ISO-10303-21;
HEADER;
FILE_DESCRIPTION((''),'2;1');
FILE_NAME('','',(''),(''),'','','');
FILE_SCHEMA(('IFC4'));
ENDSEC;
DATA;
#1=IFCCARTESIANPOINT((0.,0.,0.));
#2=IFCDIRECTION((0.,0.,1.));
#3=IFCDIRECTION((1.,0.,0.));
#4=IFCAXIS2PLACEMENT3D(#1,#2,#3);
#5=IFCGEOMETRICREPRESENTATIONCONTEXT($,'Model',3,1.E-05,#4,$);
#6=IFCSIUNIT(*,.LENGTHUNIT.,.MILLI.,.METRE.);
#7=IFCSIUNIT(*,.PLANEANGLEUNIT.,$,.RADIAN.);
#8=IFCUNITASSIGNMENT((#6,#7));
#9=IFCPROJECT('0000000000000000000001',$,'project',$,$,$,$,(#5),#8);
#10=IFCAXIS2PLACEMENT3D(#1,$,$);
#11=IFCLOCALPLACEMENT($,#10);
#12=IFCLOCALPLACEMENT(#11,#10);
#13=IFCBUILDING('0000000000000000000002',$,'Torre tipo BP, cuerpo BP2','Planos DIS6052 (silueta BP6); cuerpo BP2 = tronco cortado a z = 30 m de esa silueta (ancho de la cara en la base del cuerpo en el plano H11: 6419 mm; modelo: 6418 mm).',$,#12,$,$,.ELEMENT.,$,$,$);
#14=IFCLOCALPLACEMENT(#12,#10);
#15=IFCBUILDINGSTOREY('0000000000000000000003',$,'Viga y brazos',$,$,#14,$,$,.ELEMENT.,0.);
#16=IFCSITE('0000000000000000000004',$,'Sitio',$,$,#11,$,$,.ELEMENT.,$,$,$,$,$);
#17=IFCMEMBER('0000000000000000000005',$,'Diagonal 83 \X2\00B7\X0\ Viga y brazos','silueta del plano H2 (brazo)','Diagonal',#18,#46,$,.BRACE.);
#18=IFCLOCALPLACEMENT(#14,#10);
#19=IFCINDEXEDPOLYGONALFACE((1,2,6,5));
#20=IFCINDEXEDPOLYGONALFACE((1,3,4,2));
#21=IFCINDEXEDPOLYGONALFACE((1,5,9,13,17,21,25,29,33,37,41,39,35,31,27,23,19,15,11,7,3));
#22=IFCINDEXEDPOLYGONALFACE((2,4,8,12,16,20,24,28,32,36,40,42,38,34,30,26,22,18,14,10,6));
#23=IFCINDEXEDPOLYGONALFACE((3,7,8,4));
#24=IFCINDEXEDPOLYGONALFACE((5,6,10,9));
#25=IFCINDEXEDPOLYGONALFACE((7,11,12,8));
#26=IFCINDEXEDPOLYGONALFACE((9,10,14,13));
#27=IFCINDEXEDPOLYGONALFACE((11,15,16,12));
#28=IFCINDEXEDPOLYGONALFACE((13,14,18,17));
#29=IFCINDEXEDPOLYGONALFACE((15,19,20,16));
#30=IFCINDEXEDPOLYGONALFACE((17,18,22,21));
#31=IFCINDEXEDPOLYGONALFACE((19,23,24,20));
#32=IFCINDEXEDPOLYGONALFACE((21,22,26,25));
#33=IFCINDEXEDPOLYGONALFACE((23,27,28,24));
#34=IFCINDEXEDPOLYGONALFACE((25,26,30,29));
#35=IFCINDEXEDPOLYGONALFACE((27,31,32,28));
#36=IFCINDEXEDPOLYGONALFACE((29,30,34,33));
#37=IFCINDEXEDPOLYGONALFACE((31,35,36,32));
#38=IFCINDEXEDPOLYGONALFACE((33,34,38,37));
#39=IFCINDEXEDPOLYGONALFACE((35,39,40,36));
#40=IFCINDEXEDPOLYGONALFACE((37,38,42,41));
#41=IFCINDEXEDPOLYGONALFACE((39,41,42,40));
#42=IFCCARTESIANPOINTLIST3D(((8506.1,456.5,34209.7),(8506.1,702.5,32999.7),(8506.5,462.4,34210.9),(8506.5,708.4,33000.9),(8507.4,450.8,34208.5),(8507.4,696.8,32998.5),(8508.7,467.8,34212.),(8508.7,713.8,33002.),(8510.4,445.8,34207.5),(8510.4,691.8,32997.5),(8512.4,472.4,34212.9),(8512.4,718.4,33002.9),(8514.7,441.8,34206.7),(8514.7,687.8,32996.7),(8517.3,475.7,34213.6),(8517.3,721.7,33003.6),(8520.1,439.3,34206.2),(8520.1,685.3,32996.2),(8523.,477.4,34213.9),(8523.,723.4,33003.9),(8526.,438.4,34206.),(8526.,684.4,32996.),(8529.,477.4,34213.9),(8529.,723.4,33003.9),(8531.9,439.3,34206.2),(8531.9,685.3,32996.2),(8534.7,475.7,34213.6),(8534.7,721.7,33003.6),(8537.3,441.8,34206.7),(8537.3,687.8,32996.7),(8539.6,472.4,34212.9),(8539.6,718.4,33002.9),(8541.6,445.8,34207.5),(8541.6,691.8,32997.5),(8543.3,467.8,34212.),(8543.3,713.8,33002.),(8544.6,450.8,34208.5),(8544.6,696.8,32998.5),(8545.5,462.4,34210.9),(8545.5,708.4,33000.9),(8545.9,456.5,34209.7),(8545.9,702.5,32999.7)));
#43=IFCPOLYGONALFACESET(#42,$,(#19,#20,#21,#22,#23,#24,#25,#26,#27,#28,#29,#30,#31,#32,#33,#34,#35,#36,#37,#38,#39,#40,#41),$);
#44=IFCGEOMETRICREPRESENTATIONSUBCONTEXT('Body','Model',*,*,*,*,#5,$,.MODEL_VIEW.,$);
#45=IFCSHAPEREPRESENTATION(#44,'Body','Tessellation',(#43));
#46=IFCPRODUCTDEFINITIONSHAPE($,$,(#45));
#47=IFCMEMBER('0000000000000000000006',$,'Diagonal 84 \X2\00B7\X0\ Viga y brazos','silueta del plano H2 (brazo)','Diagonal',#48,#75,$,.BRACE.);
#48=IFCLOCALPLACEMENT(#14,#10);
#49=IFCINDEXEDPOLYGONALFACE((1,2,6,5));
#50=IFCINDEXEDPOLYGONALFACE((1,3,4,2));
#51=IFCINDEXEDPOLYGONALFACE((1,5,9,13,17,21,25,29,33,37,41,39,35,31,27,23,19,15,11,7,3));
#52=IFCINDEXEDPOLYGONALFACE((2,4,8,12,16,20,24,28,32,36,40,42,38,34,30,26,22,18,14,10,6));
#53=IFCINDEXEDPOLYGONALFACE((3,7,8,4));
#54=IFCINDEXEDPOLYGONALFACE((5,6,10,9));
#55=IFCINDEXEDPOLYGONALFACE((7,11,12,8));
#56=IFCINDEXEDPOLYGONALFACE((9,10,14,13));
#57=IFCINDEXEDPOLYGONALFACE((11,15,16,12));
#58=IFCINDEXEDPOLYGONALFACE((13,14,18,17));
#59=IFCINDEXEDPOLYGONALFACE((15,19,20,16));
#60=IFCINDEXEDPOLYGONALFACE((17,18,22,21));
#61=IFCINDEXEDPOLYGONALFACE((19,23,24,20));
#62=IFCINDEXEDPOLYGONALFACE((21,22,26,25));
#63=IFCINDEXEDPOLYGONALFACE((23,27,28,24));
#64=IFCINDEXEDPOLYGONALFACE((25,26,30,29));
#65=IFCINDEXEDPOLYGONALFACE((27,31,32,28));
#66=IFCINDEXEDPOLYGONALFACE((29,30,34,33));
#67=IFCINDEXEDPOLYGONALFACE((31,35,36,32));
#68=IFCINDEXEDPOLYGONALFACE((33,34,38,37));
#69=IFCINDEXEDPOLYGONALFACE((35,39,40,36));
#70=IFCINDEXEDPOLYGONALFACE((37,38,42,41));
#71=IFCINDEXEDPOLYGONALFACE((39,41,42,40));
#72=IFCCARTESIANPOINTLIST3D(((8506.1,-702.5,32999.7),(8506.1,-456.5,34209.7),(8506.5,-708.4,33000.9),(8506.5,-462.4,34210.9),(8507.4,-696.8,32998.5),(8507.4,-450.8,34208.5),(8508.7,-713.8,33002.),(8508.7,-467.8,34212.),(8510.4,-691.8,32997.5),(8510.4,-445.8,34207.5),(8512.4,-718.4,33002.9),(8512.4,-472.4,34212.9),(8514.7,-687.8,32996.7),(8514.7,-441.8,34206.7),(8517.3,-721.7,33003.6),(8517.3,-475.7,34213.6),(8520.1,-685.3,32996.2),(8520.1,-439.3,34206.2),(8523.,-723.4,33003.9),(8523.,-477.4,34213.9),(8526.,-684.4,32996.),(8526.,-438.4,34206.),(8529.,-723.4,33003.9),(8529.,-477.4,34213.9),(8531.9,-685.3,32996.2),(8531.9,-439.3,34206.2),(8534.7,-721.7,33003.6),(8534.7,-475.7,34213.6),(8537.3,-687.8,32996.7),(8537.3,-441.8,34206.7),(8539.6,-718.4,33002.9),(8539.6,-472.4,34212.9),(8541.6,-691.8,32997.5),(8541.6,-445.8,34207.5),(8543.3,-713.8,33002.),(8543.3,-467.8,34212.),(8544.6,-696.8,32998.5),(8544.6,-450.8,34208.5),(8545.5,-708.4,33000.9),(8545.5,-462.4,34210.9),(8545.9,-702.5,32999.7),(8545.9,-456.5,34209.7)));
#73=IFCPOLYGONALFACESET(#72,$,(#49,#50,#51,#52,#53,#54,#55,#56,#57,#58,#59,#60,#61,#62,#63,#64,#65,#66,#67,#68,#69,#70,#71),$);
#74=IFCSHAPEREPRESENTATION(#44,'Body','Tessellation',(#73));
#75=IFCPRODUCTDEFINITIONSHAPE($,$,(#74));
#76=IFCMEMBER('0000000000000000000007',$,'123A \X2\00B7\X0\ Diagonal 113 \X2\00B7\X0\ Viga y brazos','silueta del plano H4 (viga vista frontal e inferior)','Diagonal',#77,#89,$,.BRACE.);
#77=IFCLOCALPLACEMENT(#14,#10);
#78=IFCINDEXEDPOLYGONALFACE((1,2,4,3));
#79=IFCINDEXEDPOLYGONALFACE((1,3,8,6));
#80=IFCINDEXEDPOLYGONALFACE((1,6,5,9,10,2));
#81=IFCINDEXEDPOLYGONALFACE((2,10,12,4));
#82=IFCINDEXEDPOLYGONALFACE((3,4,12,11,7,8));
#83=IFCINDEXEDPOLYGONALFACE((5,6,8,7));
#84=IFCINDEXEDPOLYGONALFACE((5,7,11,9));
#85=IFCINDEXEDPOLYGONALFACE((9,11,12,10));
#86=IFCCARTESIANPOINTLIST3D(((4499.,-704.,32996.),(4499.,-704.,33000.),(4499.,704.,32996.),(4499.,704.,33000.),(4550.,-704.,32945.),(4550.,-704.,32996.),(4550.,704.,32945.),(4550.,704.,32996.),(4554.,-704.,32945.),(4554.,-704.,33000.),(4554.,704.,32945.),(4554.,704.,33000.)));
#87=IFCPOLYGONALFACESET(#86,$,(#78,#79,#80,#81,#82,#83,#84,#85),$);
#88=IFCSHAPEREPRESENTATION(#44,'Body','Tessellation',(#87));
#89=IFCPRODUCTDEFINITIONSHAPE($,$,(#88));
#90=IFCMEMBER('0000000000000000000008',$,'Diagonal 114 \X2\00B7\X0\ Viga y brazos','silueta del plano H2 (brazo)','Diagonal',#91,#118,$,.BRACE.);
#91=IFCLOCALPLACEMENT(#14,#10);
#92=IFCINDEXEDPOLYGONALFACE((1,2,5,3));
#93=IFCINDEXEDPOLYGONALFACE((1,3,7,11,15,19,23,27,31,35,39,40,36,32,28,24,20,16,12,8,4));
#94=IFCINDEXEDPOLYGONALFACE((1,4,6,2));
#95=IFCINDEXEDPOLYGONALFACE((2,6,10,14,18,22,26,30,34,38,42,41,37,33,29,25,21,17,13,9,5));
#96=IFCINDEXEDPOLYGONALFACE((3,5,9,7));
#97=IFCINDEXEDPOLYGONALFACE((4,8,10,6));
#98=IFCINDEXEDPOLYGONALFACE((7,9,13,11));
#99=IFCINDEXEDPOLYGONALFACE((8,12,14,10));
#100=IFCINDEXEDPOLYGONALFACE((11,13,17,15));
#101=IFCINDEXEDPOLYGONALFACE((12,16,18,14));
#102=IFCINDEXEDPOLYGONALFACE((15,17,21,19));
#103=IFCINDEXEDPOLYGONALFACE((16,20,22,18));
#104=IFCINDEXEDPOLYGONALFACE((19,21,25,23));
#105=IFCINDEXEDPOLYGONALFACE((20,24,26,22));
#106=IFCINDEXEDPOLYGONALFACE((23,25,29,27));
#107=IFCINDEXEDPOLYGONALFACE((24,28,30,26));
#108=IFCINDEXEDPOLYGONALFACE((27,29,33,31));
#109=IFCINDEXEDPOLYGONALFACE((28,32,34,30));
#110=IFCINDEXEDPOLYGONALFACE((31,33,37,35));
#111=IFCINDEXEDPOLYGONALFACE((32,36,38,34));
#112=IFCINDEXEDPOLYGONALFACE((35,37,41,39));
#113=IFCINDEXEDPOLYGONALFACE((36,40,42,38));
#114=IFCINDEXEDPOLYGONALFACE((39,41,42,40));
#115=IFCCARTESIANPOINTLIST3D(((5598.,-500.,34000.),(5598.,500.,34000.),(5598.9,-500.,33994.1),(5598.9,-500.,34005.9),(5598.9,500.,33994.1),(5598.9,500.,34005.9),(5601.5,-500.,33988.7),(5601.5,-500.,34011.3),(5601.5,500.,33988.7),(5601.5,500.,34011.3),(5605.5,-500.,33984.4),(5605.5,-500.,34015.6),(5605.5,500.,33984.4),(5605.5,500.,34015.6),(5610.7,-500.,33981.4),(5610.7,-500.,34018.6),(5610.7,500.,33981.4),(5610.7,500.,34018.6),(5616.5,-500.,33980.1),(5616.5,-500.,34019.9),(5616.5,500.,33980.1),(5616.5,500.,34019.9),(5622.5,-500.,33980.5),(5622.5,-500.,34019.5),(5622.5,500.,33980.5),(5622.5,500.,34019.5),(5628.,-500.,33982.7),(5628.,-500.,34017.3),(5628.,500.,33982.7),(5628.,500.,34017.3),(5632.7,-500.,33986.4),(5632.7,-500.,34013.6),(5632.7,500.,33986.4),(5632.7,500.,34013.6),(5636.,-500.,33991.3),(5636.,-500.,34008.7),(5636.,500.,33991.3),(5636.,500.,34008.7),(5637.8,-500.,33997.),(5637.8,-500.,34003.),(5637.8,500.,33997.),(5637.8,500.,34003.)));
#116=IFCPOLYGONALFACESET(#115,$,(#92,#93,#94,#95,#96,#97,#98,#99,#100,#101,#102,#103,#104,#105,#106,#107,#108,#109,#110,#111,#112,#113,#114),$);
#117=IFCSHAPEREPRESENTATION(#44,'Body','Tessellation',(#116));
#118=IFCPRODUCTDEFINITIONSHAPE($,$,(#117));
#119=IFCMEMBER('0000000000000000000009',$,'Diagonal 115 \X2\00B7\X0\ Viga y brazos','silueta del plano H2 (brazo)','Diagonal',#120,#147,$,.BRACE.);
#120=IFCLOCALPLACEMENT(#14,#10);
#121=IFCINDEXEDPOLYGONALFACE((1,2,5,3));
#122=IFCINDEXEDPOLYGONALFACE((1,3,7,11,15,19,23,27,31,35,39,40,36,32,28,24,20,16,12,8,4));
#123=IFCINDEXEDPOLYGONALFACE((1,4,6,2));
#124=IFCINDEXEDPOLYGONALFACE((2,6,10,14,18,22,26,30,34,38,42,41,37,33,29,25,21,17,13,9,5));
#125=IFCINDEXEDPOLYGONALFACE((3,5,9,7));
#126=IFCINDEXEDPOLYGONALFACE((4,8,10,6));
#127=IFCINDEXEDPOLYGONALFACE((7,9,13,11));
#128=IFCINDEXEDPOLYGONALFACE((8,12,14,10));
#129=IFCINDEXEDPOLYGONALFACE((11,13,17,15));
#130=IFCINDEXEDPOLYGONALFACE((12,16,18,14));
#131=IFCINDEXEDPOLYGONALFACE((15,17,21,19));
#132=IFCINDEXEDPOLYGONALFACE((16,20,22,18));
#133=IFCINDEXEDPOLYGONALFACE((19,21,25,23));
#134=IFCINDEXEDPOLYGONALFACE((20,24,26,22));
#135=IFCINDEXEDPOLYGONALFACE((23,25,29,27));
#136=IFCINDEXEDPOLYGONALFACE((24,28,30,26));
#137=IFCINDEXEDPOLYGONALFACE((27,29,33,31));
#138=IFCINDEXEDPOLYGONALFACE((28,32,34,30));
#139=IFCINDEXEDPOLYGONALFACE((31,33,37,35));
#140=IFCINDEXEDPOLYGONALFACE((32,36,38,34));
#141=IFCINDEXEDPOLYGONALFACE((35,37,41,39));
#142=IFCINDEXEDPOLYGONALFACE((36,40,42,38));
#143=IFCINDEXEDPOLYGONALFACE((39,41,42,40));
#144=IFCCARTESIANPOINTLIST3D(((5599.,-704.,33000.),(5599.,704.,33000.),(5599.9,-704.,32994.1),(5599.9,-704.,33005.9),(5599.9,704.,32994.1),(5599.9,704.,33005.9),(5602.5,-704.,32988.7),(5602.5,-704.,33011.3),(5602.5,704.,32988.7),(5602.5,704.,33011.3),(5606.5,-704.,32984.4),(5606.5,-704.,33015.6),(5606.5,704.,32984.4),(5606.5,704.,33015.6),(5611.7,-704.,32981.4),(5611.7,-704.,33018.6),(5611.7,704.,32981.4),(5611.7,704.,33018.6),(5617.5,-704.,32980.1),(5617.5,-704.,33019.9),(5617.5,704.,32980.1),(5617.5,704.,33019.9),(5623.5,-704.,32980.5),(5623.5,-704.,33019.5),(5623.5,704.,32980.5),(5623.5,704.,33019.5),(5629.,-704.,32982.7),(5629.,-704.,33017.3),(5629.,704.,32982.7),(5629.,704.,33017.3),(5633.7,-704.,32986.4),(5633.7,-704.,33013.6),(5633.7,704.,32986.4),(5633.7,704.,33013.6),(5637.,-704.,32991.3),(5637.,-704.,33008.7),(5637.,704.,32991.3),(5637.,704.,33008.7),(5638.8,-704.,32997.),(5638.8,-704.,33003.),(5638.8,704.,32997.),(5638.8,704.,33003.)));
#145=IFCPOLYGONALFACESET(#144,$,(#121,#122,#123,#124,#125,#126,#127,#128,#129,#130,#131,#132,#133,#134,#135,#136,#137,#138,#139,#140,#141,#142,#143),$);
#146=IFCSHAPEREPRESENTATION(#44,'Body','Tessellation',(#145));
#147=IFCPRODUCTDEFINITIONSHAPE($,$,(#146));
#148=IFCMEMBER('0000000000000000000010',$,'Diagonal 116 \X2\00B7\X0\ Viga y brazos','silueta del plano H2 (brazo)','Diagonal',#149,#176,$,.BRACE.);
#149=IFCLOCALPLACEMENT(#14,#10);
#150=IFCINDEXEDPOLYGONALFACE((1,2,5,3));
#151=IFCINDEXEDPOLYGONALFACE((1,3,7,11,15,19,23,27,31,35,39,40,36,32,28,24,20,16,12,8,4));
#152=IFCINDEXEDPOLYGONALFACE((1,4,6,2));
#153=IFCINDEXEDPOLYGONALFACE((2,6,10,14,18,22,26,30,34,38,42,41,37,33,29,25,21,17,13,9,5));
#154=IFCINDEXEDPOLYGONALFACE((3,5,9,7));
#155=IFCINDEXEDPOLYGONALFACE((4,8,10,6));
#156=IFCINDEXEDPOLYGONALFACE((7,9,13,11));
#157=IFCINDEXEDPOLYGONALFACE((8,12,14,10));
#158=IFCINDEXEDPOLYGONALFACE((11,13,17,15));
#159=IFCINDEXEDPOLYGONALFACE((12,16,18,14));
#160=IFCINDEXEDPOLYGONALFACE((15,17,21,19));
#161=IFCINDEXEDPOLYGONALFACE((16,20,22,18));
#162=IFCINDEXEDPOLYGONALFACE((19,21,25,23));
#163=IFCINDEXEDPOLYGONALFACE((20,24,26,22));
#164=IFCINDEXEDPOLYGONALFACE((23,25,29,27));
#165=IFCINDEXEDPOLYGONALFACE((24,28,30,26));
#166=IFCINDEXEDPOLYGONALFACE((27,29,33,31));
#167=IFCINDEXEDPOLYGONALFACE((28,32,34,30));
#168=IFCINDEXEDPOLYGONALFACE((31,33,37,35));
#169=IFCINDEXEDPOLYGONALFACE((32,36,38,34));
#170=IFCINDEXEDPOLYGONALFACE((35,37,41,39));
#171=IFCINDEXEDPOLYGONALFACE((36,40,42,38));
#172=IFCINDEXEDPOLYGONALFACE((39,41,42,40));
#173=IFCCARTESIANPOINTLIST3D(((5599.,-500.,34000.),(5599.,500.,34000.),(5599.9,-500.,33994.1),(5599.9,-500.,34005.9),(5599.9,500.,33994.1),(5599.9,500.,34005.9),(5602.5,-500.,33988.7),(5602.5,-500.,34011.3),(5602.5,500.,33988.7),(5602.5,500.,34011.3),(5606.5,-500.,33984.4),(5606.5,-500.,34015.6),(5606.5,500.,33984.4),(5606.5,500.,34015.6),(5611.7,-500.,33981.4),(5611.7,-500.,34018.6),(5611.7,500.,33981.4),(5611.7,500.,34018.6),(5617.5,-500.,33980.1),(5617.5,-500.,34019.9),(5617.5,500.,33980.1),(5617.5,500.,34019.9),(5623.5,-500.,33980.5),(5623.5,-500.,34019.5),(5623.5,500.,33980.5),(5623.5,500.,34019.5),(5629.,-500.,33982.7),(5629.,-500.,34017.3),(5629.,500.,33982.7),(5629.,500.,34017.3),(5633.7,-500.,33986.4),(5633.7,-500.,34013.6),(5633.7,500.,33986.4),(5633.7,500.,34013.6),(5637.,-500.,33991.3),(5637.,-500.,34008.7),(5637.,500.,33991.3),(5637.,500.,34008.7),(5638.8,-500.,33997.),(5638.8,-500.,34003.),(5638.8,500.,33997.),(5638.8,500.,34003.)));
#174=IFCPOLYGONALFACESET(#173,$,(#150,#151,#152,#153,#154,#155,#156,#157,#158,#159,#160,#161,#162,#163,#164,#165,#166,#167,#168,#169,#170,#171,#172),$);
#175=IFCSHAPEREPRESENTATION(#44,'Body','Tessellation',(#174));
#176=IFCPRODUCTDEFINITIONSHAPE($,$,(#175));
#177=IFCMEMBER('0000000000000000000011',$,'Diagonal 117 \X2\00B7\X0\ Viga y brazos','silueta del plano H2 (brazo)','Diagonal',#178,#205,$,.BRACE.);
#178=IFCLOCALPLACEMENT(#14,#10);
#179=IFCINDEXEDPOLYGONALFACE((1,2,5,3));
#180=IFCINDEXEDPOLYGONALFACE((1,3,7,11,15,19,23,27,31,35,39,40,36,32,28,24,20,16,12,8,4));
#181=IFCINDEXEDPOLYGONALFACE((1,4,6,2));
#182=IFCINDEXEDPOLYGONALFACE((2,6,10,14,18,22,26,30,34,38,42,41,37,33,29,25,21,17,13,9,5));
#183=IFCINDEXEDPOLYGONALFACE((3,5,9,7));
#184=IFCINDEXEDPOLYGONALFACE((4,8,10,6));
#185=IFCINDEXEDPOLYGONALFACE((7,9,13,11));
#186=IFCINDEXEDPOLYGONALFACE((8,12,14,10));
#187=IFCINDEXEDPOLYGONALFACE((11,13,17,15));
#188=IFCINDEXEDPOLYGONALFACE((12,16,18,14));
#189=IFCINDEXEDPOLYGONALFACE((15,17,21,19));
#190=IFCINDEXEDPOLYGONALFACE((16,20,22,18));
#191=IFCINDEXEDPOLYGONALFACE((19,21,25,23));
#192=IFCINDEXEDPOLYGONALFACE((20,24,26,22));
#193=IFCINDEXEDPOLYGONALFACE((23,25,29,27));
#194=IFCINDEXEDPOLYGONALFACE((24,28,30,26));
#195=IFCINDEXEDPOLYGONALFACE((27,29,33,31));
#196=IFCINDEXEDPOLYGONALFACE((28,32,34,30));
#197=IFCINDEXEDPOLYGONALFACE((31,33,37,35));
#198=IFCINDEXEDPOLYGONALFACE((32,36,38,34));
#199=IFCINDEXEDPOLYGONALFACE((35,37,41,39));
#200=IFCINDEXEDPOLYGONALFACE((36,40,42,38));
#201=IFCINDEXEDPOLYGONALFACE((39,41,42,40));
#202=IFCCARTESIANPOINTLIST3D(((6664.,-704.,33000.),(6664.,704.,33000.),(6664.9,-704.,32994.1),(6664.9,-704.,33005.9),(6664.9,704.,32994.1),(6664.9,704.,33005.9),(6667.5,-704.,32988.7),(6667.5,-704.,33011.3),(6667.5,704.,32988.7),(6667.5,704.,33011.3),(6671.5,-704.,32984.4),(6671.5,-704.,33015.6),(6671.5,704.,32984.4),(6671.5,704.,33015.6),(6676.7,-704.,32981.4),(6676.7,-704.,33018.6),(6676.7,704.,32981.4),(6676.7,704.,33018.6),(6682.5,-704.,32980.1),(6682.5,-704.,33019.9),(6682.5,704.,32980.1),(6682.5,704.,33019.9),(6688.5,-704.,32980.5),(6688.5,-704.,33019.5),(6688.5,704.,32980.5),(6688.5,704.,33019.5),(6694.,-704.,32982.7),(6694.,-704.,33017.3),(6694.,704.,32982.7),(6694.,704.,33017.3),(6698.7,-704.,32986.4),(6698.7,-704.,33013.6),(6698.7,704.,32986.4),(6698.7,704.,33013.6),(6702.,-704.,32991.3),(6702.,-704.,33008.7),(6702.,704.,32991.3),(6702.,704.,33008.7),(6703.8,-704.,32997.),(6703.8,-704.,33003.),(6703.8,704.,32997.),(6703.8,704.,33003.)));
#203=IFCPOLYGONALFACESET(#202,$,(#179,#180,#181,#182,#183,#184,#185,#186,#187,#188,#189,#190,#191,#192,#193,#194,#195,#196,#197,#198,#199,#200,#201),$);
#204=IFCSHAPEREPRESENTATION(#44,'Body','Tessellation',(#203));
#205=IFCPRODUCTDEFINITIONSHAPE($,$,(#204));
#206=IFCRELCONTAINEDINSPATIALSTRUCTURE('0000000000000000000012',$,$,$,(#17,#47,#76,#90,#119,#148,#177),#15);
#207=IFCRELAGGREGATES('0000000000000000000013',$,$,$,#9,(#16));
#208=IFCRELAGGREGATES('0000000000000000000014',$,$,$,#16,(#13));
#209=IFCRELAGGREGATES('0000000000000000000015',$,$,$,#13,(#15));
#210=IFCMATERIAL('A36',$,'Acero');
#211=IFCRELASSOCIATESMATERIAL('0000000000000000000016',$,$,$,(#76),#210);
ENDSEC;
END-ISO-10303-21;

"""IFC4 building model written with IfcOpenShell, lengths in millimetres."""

from ifc_helpers import new_model, si_unit, frame, frame_2d, origin, origin_with_axes, place, context, subcontext, project, spatial, circle, l_section, extrude, material, element, save


model = new_model("IFC4")

# Units and contexts
model_context = context("Model", 3, precision=1e-05, world=origin_with_axes())
body_context = subcontext(model_context, "Body", "Model", "MODEL_VIEW")
ifc_project = project(units=[si_unit("LENGTHUNIT", "METRE", prefix="MILLI"), si_unit("PLANEANGLEUNIT", "RADIAN")], contexts=[model_context])

# Site, building, storey
site_placement = place(None, origin())
site = spatial("IfcSite", under=ifc_project, at=site_placement, Name="Sitio", CompositionType="ELEMENT")
building_placement = place(site_placement, origin())
building = spatial("IfcBuilding", under=site, at=building_placement, Name="Torre tipo BP, cuerpo BP2", Description="Planos DIS6052 (silueta BP6); cuerpo BP2 = tronco cortado a z = 30 m de esa silueta (ancho de la cara en la base del cuerpo en el plano H11: 6419 mm; modelo: 6418 mm).", CompositionType="ELEMENT")
storey_placement = place(building_placement, origin())
storey = spatial("IfcBuildingStorey", under=building, at=storey_placement, Name="Viga y brazos", CompositionType="ELEMENT", Elevation=0.0)

# Members
ifc_material_1 = material(Name="A36", Category="Acero")
for number, where, z_axis, x_axis, name in (
    (1, (8526.0, 458.0, 34210.0), (0.0, 0.19923, -0.979953), (0.0, -0.979953, -0.19923), "Diagonal 83 · Viga y brazos"),
    (2, (8526.0, -458.0, 34210.0), (0.0, -0.19923, -0.979953), (0.0, 0.979953, -0.19923), "Diagonal 84 · Viga y brazos"),
):
    element("IfcMember", number, at=place(storey_placement, frame(where, z_axis=z_axis, x_axis=x_axis)), inside=storey, Name=name, Description="silueta del plano H2 (brazo)", ObjectType="Diagonal", PredefinedType="BRACE", context=body_context, shape_type="SweptSolid", body=[
        extrude(circle(Radius=20.0), None, (0.0, 0.0, 1.0), 1234.8),
    ])
member_1_placement = place(storey_placement, frame((4554.0, 704.0, 33000.0), z_axis=(0.0, -1.0, 0.0), x_axis=(-1.0, 0.0, 0.0)))
element("IfcMember", 3, at=member_1_placement, inside=storey, material=ifc_material_1, Name="123A · Diagonal 113 · Viga y brazos", Description="silueta del plano H4 (viga vista frontal e inferior)", ObjectType="Diagonal", PredefinedType="BRACE", context=body_context, shape_type="SweptSolid", body=[
    extrude(l_section(Depth=55.0, Width=55.0, Thickness=4.0, at=frame_2d((27.5, 27.5))), None, (0.0, 0.0, 1.0), 1408.0),
])
member_2_placement = place(storey_placement, frame((5618.0, 500.0, 34000.0), z_axis=(0.0, -1.0, 0.0), x_axis=(-1.0, 0.0, 0.0)))
element("IfcMember", 4, at=member_2_placement, inside=storey, Name="Diagonal 114 · Viga y brazos", Description="silueta del plano H2 (brazo)", ObjectType="Diagonal", PredefinedType="BRACE", context=body_context, shape_type="SweptSolid", body=[
    extrude(circle(Radius=20.0), None, (0.0, 0.0, 1.0), 1000.0),
])
member_3_placement = place(storey_placement, frame((5619.0, 704.0, 33000.0), z_axis=(0.0, -1.0, 0.0), x_axis=(-1.0, 0.0, 0.0)))
element("IfcMember", 5, at=member_3_placement, inside=storey, Name="Diagonal 115 · Viga y brazos", Description="silueta del plano H2 (brazo)", ObjectType="Diagonal", PredefinedType="BRACE", context=body_context, shape_type="SweptSolid", body=[
    extrude(circle(Radius=20.0), None, (0.0, 0.0, 1.0), 1408.0),
])
member_4_placement = place(storey_placement, frame((5619.0, 500.0, 34000.0), z_axis=(0.0, -1.0, 0.0), x_axis=(-1.0, 0.0, 0.0)))
element("IfcMember", 6, at=member_4_placement, inside=storey, Name="Diagonal 116 · Viga y brazos", Description="silueta del plano H2 (brazo)", ObjectType="Diagonal", PredefinedType="BRACE", context=body_context, shape_type="SweptSolid", body=[
    extrude(circle(Radius=20.0), None, (0.0, 0.0, 1.0), 1000.0),
])
member_5_placement = place(storey_placement, frame((6684.0, 704.0, 33000.0), z_axis=(0.0, -1.0, 0.0), x_axis=(-1.0, 0.0, 0.0)))
element("IfcMember", 7, at=member_5_placement, inside=storey, Name="Diagonal 117 · Viga y brazos", Description="silueta del plano H2 (brazo)", ObjectType="Diagonal", PredefinedType="BRACE", context=body_context, shape_type="SweptSolid", body=[
    extrude(circle(Radius=20.0), None, (0.0, 0.0, 1.0), 1408.0),
])

save(model, "model.ifc")
